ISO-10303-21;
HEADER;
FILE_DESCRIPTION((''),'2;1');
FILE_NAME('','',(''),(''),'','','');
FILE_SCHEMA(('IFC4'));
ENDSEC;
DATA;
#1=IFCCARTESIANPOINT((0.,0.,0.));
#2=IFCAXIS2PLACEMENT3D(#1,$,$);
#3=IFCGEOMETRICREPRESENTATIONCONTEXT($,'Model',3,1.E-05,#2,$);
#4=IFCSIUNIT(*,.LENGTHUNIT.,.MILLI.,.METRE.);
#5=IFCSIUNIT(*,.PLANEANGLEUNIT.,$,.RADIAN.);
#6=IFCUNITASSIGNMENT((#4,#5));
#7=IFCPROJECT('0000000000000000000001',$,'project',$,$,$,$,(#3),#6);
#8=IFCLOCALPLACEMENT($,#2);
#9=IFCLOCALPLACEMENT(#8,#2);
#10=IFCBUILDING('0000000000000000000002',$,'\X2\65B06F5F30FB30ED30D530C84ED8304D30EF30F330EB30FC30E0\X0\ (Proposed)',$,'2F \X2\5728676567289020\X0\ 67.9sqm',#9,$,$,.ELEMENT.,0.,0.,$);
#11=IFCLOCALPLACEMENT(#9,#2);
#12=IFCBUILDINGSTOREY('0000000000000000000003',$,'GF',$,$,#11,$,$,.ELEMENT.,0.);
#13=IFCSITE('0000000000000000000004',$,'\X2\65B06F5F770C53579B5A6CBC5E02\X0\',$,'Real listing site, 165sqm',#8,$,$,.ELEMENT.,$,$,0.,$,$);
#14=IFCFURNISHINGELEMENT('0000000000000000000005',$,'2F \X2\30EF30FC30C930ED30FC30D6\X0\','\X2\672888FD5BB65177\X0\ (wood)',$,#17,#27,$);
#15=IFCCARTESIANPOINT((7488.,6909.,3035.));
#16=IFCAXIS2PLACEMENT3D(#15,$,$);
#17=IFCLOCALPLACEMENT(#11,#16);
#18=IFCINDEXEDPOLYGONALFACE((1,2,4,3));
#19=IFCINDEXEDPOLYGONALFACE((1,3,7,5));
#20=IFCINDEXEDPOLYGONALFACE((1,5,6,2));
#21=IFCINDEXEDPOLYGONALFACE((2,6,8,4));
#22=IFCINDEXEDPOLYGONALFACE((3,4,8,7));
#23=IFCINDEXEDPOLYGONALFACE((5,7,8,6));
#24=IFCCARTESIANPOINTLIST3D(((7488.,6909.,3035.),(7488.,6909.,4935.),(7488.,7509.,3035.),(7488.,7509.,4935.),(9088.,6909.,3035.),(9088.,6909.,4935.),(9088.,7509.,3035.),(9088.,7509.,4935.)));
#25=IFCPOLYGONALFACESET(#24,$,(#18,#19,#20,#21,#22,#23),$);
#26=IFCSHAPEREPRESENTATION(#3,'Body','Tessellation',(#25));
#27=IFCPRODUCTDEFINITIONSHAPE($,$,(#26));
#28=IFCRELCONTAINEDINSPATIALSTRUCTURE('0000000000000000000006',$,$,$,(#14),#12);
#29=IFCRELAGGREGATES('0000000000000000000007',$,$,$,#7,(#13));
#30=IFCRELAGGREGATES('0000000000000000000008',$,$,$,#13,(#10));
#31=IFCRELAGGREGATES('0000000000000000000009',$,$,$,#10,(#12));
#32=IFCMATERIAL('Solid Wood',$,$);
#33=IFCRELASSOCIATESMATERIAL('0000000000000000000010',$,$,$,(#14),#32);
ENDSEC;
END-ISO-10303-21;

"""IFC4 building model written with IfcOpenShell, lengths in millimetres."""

from ifc_helpers import new_model, si_unit, frame, frame_2d, origin, place, context, project, spatial, rectangle, extrude, material, element, save


model = new_model("IFC4")

# Units and contexts
model_context = context("Model", 3, precision=1e-05, world=origin())
ifc_project = project(units=[si_unit("LENGTHUNIT", "METRE", prefix="MILLI"), si_unit("PLANEANGLEUNIT", "RADIAN")], contexts=[model_context])

# Site, building, storey
site_placement = place(None, origin())
site = spatial("IfcSite", under=ifc_project, at=site_placement, Name="新潟県南魚沼市", ObjectType="Real listing site, 165sqm", CompositionType="ELEMENT", RefElevation=0.0)
building_placement = place(site_placement, origin())
building = spatial("IfcBuilding", under=site, at=building_placement, Name="新潟・ロフト付きワンルーム (Proposed)", ObjectType="2F 在来木造 67.9sqm", CompositionType="ELEMENT", ElevationOfRefHeight=0.0, ElevationOfTerrain=0.0)
storey_placement = place(building_placement, origin())
storey = spatial("IfcBuildingStorey", under=building, at=storey_placement, Name="GF", CompositionType="ELEMENT", Elevation=0.0)

# Shared definitions
ifc_material_1 = material(Name="Solid Wood")

# Furnishing element
furnishing_placement = place(storey_placement, frame((7488.0, 6909.0, 3035.0)))
element("IfcFurnishingElement", 1, at=furnishing_placement, inside=storey, material=ifc_material_1, Name="2F ワードローブ", Description="木製家具 (wood)", context=model_context, shape_type="SweptSolid", body=[
    extrude(rectangle(XDim=1600.0, YDim=600.0, at=frame_2d((800.0, 300.0))), frame((7488.0, 6909.0, 3035.0)), (0.0, 0.0, 1.0), 1900.0),
])

save(model, "model.ifc")
